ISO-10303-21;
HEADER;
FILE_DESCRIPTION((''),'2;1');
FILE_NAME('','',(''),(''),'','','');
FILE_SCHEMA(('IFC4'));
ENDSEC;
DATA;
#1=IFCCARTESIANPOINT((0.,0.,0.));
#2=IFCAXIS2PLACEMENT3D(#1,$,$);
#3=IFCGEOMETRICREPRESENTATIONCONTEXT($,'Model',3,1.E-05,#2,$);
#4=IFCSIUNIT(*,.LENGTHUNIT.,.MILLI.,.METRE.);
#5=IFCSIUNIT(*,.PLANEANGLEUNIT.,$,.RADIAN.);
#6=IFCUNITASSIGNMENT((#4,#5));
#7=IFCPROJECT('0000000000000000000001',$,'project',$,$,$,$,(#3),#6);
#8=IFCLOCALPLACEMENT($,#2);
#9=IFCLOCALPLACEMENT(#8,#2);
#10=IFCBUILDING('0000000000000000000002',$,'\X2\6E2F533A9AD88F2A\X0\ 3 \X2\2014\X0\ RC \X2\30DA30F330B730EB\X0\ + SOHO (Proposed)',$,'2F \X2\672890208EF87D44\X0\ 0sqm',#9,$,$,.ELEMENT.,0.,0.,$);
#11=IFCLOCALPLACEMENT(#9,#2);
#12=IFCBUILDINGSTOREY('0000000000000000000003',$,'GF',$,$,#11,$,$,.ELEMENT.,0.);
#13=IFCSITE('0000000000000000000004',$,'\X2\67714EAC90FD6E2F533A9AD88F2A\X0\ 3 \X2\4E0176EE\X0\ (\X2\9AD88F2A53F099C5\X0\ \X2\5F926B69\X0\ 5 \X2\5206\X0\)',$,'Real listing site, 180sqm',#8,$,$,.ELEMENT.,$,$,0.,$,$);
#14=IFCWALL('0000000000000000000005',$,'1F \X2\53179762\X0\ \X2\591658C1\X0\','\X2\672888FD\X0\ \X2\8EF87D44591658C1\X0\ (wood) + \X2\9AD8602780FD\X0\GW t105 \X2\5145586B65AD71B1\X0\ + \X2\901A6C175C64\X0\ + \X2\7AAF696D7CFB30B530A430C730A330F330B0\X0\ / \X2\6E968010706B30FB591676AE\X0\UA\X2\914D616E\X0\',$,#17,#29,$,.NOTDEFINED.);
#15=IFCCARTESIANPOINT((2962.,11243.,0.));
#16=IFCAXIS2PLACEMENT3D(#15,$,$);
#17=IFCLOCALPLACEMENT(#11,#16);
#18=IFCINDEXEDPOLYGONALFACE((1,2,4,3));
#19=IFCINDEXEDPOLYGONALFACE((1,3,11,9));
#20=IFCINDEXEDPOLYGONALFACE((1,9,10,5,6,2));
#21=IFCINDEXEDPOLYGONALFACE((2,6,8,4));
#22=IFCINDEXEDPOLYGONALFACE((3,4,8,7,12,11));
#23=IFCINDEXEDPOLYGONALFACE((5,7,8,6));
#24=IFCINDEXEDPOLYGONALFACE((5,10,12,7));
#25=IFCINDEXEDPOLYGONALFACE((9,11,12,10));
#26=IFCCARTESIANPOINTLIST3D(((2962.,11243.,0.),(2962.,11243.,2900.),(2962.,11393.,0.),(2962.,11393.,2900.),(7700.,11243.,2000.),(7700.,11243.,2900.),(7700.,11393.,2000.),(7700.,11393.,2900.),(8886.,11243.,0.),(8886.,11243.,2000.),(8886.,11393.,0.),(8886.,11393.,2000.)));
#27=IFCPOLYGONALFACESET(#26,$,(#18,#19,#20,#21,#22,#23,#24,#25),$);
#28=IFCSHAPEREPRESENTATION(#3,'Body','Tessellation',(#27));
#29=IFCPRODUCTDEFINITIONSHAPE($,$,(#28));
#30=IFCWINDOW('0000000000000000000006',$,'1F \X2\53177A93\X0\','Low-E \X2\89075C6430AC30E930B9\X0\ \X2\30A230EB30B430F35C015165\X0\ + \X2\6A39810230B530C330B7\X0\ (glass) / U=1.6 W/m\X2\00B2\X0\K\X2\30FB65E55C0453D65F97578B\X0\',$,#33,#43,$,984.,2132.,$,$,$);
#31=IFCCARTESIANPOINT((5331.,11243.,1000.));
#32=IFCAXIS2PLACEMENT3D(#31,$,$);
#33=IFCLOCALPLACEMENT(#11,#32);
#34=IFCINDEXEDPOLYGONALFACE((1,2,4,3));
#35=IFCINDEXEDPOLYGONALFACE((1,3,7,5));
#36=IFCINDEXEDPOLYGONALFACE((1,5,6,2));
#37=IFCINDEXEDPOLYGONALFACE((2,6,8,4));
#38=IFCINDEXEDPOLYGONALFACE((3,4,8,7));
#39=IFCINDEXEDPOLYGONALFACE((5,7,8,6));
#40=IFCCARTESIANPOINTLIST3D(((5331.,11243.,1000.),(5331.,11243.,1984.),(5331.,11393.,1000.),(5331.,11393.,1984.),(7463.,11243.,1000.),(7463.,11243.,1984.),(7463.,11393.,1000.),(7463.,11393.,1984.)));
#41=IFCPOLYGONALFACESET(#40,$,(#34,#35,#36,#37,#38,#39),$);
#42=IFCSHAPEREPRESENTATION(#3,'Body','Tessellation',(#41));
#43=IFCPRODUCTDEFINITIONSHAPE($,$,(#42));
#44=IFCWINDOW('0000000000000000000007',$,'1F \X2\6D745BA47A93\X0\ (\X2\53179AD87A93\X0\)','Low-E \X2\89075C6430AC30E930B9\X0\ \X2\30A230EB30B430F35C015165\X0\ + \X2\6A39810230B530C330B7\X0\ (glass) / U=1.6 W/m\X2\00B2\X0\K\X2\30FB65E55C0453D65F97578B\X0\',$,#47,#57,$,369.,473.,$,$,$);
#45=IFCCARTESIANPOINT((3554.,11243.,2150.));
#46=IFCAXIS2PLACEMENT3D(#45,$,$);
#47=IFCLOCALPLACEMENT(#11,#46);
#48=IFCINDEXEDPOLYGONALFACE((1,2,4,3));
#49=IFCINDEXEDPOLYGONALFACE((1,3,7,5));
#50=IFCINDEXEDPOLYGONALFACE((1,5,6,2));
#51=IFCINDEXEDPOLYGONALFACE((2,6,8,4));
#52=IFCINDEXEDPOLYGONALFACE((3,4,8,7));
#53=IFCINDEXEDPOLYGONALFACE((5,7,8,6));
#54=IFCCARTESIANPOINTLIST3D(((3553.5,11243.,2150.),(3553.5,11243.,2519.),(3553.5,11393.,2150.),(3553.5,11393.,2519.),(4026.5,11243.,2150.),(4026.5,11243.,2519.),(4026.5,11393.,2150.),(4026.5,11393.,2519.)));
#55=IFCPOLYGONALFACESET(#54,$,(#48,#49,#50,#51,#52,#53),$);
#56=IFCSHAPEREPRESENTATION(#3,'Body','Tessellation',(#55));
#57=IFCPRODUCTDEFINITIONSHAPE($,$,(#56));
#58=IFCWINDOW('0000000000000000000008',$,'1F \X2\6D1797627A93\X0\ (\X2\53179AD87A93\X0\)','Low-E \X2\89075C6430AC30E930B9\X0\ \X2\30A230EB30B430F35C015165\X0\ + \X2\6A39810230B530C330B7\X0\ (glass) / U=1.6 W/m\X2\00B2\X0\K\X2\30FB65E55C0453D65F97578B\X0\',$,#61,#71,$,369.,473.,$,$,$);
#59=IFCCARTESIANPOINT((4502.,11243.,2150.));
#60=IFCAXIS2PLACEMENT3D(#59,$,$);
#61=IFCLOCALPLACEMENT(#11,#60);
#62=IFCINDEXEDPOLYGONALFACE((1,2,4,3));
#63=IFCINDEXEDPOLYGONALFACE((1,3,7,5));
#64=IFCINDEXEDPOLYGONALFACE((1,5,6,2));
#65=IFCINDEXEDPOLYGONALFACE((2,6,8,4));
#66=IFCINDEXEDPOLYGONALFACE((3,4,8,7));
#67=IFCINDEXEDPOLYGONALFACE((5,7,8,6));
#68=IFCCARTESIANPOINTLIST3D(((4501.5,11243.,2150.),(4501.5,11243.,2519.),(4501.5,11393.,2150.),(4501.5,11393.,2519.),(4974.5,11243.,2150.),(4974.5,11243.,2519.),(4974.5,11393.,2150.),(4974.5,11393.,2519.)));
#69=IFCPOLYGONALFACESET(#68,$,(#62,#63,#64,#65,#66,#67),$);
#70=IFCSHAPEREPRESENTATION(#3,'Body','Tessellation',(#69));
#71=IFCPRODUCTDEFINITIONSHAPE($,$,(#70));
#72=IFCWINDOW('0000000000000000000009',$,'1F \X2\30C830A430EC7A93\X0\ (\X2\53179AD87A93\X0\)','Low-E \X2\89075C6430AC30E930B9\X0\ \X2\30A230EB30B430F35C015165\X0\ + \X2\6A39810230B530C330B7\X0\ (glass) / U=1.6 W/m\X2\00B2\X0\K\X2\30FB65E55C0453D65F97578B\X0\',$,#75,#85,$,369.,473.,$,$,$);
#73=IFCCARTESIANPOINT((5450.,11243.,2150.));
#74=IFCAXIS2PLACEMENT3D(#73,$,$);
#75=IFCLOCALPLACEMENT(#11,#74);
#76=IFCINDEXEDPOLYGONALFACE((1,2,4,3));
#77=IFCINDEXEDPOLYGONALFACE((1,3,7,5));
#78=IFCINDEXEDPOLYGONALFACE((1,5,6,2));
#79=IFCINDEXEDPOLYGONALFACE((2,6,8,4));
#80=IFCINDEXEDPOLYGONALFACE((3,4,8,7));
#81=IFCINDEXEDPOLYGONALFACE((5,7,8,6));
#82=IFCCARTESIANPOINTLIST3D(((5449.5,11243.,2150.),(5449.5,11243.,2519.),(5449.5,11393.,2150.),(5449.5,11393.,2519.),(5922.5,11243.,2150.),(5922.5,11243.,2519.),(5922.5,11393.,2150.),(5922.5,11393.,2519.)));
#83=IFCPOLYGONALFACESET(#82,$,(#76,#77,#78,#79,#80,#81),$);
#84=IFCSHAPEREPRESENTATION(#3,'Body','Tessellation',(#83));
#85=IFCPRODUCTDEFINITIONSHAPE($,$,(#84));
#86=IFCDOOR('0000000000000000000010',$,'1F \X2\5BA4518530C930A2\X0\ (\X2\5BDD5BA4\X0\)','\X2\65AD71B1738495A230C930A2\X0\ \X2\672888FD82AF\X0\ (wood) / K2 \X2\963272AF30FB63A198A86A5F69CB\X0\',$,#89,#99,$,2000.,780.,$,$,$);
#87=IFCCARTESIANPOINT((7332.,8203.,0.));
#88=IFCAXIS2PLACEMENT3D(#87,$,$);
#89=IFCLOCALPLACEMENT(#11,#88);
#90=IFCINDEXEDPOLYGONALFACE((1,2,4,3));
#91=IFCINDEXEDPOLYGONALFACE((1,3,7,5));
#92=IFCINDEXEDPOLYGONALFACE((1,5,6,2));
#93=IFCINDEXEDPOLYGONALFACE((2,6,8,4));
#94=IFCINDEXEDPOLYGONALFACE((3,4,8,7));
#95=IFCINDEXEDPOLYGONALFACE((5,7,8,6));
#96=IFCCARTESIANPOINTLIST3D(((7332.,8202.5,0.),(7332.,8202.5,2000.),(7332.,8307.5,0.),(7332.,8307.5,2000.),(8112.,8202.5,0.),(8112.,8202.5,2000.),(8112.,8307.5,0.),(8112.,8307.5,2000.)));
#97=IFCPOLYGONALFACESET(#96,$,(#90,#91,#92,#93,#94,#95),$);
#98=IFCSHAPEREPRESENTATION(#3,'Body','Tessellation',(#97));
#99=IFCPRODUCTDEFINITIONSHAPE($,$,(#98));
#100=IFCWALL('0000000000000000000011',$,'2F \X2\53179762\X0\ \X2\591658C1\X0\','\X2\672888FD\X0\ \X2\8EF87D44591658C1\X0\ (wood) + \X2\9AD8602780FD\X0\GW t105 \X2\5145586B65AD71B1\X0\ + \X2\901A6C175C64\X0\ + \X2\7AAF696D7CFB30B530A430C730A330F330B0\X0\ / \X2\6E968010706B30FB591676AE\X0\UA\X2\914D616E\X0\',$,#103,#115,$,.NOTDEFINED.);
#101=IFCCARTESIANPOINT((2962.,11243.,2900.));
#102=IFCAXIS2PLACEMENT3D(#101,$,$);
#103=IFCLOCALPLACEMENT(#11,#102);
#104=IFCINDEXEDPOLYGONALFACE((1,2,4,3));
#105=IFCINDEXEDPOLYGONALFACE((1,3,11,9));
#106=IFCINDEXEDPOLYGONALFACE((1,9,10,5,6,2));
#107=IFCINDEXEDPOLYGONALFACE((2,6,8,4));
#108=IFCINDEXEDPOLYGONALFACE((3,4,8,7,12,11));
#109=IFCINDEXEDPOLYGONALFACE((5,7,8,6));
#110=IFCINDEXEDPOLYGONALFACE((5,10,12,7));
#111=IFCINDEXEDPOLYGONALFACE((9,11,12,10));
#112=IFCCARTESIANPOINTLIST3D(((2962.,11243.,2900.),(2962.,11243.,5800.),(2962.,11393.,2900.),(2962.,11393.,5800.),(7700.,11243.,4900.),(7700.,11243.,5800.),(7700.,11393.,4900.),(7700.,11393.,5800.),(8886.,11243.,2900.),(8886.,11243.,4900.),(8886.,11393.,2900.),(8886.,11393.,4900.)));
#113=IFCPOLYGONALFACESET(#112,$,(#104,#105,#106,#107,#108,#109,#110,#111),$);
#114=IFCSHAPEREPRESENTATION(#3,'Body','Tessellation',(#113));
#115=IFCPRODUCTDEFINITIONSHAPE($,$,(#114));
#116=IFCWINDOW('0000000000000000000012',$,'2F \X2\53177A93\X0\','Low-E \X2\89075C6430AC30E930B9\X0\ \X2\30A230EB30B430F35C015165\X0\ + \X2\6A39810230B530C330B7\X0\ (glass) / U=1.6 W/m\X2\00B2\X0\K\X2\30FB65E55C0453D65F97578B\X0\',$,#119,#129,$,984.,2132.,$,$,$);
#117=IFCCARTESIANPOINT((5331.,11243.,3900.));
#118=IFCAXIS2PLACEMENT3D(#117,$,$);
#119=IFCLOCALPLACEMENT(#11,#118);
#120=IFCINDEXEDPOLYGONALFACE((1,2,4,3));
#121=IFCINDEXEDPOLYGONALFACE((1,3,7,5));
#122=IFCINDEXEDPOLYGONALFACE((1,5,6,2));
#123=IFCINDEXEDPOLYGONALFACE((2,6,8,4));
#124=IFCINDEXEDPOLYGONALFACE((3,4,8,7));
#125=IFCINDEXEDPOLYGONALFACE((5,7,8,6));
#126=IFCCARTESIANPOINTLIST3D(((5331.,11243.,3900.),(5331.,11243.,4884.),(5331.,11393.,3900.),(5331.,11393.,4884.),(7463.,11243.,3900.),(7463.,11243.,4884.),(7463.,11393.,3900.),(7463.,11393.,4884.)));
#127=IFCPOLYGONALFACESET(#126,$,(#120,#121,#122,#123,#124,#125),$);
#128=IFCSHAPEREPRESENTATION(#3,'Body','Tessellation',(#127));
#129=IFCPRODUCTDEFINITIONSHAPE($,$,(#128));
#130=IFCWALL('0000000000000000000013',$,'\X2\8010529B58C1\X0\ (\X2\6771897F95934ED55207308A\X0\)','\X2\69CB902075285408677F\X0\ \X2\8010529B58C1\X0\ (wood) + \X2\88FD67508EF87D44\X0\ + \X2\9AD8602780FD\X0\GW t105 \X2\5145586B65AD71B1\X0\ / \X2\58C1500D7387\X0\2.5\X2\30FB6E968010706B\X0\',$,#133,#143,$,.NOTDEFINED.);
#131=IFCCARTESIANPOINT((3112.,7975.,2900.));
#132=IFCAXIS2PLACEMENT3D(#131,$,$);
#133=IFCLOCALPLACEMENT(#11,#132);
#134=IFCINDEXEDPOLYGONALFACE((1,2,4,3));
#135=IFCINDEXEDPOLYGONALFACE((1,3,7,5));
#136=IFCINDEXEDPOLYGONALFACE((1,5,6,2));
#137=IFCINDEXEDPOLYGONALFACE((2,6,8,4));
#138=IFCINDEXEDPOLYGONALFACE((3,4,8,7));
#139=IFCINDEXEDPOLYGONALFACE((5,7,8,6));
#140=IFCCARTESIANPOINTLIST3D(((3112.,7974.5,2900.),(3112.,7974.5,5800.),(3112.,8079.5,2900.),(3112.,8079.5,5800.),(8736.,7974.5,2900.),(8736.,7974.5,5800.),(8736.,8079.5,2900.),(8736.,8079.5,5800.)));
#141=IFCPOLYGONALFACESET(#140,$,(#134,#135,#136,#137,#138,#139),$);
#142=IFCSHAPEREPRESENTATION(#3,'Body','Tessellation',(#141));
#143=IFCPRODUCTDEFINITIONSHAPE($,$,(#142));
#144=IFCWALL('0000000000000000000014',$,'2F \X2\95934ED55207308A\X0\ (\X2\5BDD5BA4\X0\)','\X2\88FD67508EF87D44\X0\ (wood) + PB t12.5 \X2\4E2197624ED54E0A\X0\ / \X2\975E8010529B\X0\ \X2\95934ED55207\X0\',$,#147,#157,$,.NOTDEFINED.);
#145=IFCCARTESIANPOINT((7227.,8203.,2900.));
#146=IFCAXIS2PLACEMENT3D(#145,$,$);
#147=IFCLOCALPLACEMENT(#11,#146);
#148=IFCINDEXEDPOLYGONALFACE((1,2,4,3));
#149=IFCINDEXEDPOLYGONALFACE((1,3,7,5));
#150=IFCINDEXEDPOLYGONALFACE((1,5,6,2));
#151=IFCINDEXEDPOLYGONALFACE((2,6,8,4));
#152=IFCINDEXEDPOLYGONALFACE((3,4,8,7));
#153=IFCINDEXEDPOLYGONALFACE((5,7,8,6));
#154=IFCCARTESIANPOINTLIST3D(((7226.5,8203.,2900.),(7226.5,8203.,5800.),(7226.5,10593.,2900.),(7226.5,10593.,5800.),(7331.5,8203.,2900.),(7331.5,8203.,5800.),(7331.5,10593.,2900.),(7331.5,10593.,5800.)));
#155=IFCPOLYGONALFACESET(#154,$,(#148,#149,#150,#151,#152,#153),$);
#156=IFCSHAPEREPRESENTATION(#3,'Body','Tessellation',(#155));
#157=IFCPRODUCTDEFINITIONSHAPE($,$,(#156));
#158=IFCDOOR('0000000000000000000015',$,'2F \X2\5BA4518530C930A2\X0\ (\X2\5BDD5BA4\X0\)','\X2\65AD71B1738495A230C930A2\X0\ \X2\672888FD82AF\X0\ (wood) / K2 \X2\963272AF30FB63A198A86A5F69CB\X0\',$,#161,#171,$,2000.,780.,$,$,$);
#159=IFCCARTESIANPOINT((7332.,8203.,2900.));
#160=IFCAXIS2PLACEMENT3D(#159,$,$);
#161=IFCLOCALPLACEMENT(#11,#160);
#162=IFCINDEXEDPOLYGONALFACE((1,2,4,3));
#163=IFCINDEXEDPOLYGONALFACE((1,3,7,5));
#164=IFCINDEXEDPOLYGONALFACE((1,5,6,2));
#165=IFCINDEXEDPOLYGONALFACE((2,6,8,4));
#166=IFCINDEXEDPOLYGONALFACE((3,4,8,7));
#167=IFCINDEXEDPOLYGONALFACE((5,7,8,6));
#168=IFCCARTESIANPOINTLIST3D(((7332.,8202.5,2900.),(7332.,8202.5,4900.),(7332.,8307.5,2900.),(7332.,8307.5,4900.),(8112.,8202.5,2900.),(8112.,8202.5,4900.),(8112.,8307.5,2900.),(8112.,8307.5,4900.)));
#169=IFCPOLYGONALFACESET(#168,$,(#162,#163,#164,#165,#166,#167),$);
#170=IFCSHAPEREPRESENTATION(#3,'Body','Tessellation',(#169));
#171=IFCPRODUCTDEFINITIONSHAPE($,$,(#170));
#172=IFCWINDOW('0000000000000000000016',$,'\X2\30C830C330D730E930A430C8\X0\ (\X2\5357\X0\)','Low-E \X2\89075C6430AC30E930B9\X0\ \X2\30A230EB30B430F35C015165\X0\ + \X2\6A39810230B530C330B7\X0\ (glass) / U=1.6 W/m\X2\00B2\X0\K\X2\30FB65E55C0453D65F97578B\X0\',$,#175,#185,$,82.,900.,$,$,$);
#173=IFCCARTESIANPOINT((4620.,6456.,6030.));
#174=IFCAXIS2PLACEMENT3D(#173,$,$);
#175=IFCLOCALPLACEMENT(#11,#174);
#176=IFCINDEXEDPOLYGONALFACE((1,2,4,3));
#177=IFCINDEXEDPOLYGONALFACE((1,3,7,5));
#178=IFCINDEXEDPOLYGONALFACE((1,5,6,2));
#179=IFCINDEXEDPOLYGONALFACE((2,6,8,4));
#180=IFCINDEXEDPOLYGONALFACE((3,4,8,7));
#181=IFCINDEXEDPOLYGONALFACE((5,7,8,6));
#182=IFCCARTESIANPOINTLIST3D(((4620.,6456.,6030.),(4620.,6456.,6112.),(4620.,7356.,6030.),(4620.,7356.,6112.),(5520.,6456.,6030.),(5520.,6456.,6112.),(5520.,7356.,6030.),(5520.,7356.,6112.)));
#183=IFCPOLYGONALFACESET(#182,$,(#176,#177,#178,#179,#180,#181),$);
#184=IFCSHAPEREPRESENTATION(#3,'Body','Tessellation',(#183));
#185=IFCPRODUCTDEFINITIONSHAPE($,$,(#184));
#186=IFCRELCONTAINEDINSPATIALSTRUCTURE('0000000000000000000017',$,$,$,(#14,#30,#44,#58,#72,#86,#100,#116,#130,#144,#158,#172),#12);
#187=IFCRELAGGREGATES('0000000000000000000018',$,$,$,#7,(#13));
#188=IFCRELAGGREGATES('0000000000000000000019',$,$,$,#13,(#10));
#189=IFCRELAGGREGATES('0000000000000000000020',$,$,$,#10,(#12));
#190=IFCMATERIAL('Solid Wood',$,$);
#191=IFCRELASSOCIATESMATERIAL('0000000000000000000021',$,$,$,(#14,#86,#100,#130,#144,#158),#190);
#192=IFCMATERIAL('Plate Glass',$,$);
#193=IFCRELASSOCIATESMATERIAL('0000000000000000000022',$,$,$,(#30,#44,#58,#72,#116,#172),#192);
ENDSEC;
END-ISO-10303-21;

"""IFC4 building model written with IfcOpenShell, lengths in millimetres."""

from ifc_helpers import new_model, si_unit, frame, frame_2d, origin, place, context, project, spatial, rectangle, extrude, material, element, fill, save


model = new_model("IFC4")

# Units and contexts
model_context = context("Model", 3, precision=1e-05, world=origin())
ifc_project = project(units=[si_unit("LENGTHUNIT", "METRE", prefix="MILLI"), si_unit("PLANEANGLEUNIT", "RADIAN")], contexts=[model_context])

# Site, building, storey
site_placement = place(None, origin())
site = spatial("IfcSite", under=ifc_project, at=site_placement, Name="東京都港区高輪 3 丁目 (高輪台駅 徒歩 5 分)", ObjectType="Real listing site, 180sqm", CompositionType="ELEMENT", RefElevation=0.0)
building_placement = place(site_placement, origin())
building = spatial("IfcBuilding", under=site, at=building_placement, Name="港区高輪 3 — RC ペンシル + SOHO (Proposed)", ObjectType="2F 木造軸組 0sqm", CompositionType="ELEMENT", ElevationOfRefHeight=0.0, ElevationOfTerrain=0.0)
storey_placement = place(building_placement, origin())
storey = spatial("IfcBuildingStorey", under=building, at=storey_placement, Name="GF", CompositionType="ELEMENT", Elevation=0.0)

# Wall, openings, windows
ifc_material_1 = material(Name="Solid Wood")
wall_1_placement = place(storey_placement, frame((2962.0, 11243.0, 0.0)))
wall_1 = element("IfcWall", 1, at=wall_1_placement, inside=storey, material=ifc_material_1, Name="1F 北面 外壁", Description="木製 軸組外壁 (wood) + 高性能GW t105 充填断熱 + 通気層 + 窯業系サイディング / 準耐火・外皮UA配慮", PredefinedType="NOTDEFINED", context=model_context, shape_type="SweptSolid", body=[
    extrude(rectangle(XDim=5924.0, YDim=150.0, at=frame_2d((2962.0, 75.0))), frame((2962.0, 11243.0, 0.0)), (0.0, 0.0, 1.0), 2900.0),
])
opening_1_placement = place(storey_placement, frame((5331.0, 11243.0, 1000.0)))
opening_1 = element("IfcOpeningElement", 2, at=opening_1_placement, cuts=wall_1, PredefinedType="NOTDEFINED", context=model_context, shape_type="SweptSolid", body=[
    extrude(rectangle(XDim=2132.0, YDim=150.0, at=frame_2d((1066.0, 75.0))), frame((5331.0, 11243.0, 1000.0)), (0.0, 0.0, 1.0), 984.0),
])
opening_2_placement = place(storey_placement, frame((3554.0, 11243.0, 2150.0)))
opening_2 = element("IfcOpeningElement", 3, at=opening_2_placement, cuts=wall_1, PredefinedType="NOTDEFINED", context=model_context, shape_type="SweptSolid", body=[
    extrude(rectangle(XDim=473.0, YDim=150.0, at=frame_2d((236.0, 75.0))), frame((3554.0, 11243.0, 2150.0)), (0.0, 0.0, 1.0), 369.0),
])
opening_3_placement = place(storey_placement, frame((4502.0, 11243.0, 2150.0)))
opening_3 = element("IfcOpeningElement", 4, at=opening_3_placement, cuts=wall_1, PredefinedType="NOTDEFINED", context=model_context, shape_type="SweptSolid", body=[
    extrude(rectangle(XDim=473.0, YDim=150.0, at=frame_2d((236.0, 75.0))), frame((4502.0, 11243.0, 2150.0)), (0.0, 0.0, 1.0), 369.0),
])
opening_4_placement = place(storey_placement, frame((5450.0, 11243.0, 2150.0)))
opening_4 = element("IfcOpeningElement", 5, at=opening_4_placement, cuts=wall_1, PredefinedType="NOTDEFINED", context=model_context, shape_type="SweptSolid", body=[
    extrude(rectangle(XDim=473.0, YDim=150.0, at=frame_2d((236.0, 75.0))), frame((5450.0, 11243.0, 2150.0)), (0.0, 0.0, 1.0), 369.0),
])
ifc_material_2 = material(Name="Plate Glass")
window_1_placement = place(storey_placement, frame((5331.0, 11243.0, 1000.0)))
window_1 = element("IfcWindow", 6, at=window_1_placement, inside=storey, material=ifc_material_2, Name="1F 北窓", Description="Low-E 複層ガラス アルゴン封入 + 樹脂サッシ (glass) / U=1.6 W/m²K・日射取得型", OverallHeight=984.0, OverallWidth=2132.0, context=model_context, shape_type="SweptSolid", body=[
    extrude(rectangle(XDim=2132.0, YDim=150.0, at=frame_2d((1066.0, 75.0))), frame((5331.0, 11243.0, 1000.0)), (0.0, 0.0, 1.0), 984.0),
])
fill(opening_1, window_1)
window_2_placement = place(storey_placement, frame((3554.0, 11243.0, 2150.0)))
window_2 = element("IfcWindow", 7, at=window_2_placement, inside=storey, material=ifc_material_2, Name="1F 浴室窓 (北高窓)", Description="Low-E 複層ガラス アルゴン封入 + 樹脂サッシ (glass) / U=1.6 W/m²K・日射取得型", OverallHeight=369.0, OverallWidth=473.0, context=model_context, shape_type="SweptSolid", body=[
    extrude(rectangle(XDim=473.0, YDim=150.0, at=frame_2d((236.0, 75.0))), frame((3554.0, 11243.0, 2150.0)), (0.0, 0.0, 1.0), 369.0),
])
fill(opening_2, window_2)
window_3_placement = place(storey_placement, frame((4502.0, 11243.0, 2150.0)))
window_3 = element("IfcWindow", 8, at=window_3_placement, inside=storey, material=ifc_material_2, Name="1F 洗面窓 (北高窓)", Description="Low-E 複層ガラス アルゴン封入 + 樹脂サッシ (glass) / U=1.6 W/m²K・日射取得型", OverallHeight=369.0, OverallWidth=473.0, context=model_context, shape_type="SweptSolid", body=[
    extrude(rectangle(XDim=473.0, YDim=150.0, at=frame_2d((236.0, 75.0))), frame((4502.0, 11243.0, 2150.0)), (0.0, 0.0, 1.0), 369.0),
])
fill(opening_3, window_3)
window_4_placement = place(storey_placement, frame((5450.0, 11243.0, 2150.0)))
window_4 = element("IfcWindow", 9, at=window_4_placement, inside=storey, material=ifc_material_2, Name="1F トイレ窓 (北高窓)", Description="Low-E 複層ガラス アルゴン封入 + 樹脂サッシ (glass) / U=1.6 W/m²K・日射取得型", OverallHeight=369.0, OverallWidth=473.0, context=model_context, shape_type="SweptSolid", body=[
    extrude(rectangle(XDim=473.0, YDim=150.0, at=frame_2d((236.0, 75.0))), frame((5450.0, 11243.0, 2150.0)), (0.0, 0.0, 1.0), 369.0),
])
fill(opening_4, window_4)

# Door
door_1_placement = place(storey_placement, frame((7332.0, 8203.0, 0.0)))
element("IfcDoor", 10, at=door_1_placement, inside=storey, material=ifc_material_1, Name="1F 室内ドア (寝室)", Description="断熱玄関ドア 木製芯 (wood) / K2 防犯・採風機構", OverallHeight=2000.0, OverallWidth=780.0, context=model_context, shape_type="SweptSolid", body=[
    extrude(rectangle(XDim=780.0, YDim=105.0, at=frame_2d((390.0, 52.0))), frame((7332.0, 8203.0, 0.0)), (0.0, 0.0, 1.0), 2000.0),
])

# Wall, opening, window
wall_2_placement = place(storey_placement, frame((2962.0, 11243.0, 2900.0)))
wall_2 = element("IfcWall", 11, at=wall_2_placement, inside=storey, material=ifc_material_1, Name="2F 北面 外壁", Description="木製 軸組外壁 (wood) + 高性能GW t105 充填断熱 + 通気層 + 窯業系サイディング / 準耐火・外皮UA配慮", PredefinedType="NOTDEFINED", context=model_context, shape_type="SweptSolid", body=[
    extrude(rectangle(XDim=5924.0, YDim=150.0, at=frame_2d((2962.0, 75.0))), frame((2962.0, 11243.0, 2900.0)), (0.0, 0.0, 1.0), 2900.0),
])
opening_5_placement = place(storey_placement, frame((5331.0, 11243.0, 3900.0)))
opening_5 = element("IfcOpeningElement", 12, at=opening_5_placement, cuts=wall_2, PredefinedType="NOTDEFINED", context=model_context, shape_type="SweptSolid", body=[
    extrude(rectangle(XDim=2132.0, YDim=150.0, at=frame_2d((1066.0, 75.0))), frame((5331.0, 11243.0, 3900.0)), (0.0, 0.0, 1.0), 984.0),
])
window_5_placement = place(storey_placement, frame((5331.0, 11243.0, 3900.0)))
window_5 = element("IfcWindow", 13, at=window_5_placement, inside=storey, material=ifc_material_2, Name="2F 北窓", Description="Low-E 複層ガラス アルゴン封入 + 樹脂サッシ (glass) / U=1.6 W/m²K・日射取得型", OverallHeight=984.0, OverallWidth=2132.0, context=model_context, shape_type="SweptSolid", body=[
    extrude(rectangle(XDim=2132.0, YDim=150.0, at=frame_2d((1066.0, 75.0))), frame((5331.0, 11243.0, 3900.0)), (0.0, 0.0, 1.0), 984.0),
])
fill(opening_5, window_5)

# Walls
wall_3_placement = place(storey_placement, frame((3112.0, 7975.0, 2900.0)))
element("IfcWall", 14, at=wall_3_placement, inside=storey, material=ifc_material_1, Name="耐力壁 (東西間仕切り)", Description="構造用合板 耐力壁 (wood) + 製材軸組 + 高性能GW t105 充填断熱 / 壁倍率2.5・準耐火", PredefinedType="NOTDEFINED", context=model_context, shape_type="SweptSolid", body=[
    extrude(rectangle(XDim=5624.0, YDim=105.0, at=frame_2d((2812.0, 52.0))), frame((3112.0, 7975.0, 2900.0)), (0.0, 0.0, 1.0), 2900.0),
])
wall_4_placement = place(storey_placement, frame((7227.0, 8203.0, 2900.0)))
element("IfcWall", 15, at=wall_4_placement, inside=storey, material=ifc_material_1, Name="2F 間仕切り (寝室)", Description="製材軸組 (wood) + PB t12.5 両面仕上 / 非耐力 間仕切", PredefinedType="NOTDEFINED", context=model_context, shape_type="SweptSolid", body=[
    extrude(rectangle(XDim=105.0, YDim=2390.0, at=frame_2d((52.0, 1195.0))), frame((7227.0, 8203.0, 2900.0)), (0.0, 0.0, 1.0), 2900.0),
])

# Door
door_2_placement = place(storey_placement, frame((7332.0, 8203.0, 2900.0)))
element("IfcDoor", 16, at=door_2_placement, inside=storey, material=ifc_material_1, Name="2F 室内ドア (寝室)", Description="断熱玄関ドア 木製芯 (wood) / K2 防犯・採風機構", OverallHeight=2000.0, OverallWidth=780.0, context=model_context, shape_type="SweptSolid", body=[
    extrude(rectangle(XDim=780.0, YDim=105.0, at=frame_2d((390.0, 52.0))), frame((7332.0, 8203.0, 2900.0)), (0.0, 0.0, 1.0), 2000.0),
])

# Window
window_6_placement = place(storey_placement, frame((4620.0, 6456.0, 6030.0)))
element("IfcWindow", 17, at=window_6_placement, inside=storey, material=ifc_material_2, Name="トップライト (南)", Description="Low-E 複層ガラス アルゴン封入 + 樹脂サッシ (glass) / U=1.6 W/m²K・日射取得型", OverallHeight=82.0, OverallWidth=900.0, context=model_context, shape_type="SweptSolid", body=[
    extrude(rectangle(XDim=900.0, YDim=900.0, at=frame_2d((450.0, 450.0))), frame((4620.0, 6456.0, 6030.0)), (0.0, 0.0, 1.0), 82.0),
])

save(model, "model.ifc")
